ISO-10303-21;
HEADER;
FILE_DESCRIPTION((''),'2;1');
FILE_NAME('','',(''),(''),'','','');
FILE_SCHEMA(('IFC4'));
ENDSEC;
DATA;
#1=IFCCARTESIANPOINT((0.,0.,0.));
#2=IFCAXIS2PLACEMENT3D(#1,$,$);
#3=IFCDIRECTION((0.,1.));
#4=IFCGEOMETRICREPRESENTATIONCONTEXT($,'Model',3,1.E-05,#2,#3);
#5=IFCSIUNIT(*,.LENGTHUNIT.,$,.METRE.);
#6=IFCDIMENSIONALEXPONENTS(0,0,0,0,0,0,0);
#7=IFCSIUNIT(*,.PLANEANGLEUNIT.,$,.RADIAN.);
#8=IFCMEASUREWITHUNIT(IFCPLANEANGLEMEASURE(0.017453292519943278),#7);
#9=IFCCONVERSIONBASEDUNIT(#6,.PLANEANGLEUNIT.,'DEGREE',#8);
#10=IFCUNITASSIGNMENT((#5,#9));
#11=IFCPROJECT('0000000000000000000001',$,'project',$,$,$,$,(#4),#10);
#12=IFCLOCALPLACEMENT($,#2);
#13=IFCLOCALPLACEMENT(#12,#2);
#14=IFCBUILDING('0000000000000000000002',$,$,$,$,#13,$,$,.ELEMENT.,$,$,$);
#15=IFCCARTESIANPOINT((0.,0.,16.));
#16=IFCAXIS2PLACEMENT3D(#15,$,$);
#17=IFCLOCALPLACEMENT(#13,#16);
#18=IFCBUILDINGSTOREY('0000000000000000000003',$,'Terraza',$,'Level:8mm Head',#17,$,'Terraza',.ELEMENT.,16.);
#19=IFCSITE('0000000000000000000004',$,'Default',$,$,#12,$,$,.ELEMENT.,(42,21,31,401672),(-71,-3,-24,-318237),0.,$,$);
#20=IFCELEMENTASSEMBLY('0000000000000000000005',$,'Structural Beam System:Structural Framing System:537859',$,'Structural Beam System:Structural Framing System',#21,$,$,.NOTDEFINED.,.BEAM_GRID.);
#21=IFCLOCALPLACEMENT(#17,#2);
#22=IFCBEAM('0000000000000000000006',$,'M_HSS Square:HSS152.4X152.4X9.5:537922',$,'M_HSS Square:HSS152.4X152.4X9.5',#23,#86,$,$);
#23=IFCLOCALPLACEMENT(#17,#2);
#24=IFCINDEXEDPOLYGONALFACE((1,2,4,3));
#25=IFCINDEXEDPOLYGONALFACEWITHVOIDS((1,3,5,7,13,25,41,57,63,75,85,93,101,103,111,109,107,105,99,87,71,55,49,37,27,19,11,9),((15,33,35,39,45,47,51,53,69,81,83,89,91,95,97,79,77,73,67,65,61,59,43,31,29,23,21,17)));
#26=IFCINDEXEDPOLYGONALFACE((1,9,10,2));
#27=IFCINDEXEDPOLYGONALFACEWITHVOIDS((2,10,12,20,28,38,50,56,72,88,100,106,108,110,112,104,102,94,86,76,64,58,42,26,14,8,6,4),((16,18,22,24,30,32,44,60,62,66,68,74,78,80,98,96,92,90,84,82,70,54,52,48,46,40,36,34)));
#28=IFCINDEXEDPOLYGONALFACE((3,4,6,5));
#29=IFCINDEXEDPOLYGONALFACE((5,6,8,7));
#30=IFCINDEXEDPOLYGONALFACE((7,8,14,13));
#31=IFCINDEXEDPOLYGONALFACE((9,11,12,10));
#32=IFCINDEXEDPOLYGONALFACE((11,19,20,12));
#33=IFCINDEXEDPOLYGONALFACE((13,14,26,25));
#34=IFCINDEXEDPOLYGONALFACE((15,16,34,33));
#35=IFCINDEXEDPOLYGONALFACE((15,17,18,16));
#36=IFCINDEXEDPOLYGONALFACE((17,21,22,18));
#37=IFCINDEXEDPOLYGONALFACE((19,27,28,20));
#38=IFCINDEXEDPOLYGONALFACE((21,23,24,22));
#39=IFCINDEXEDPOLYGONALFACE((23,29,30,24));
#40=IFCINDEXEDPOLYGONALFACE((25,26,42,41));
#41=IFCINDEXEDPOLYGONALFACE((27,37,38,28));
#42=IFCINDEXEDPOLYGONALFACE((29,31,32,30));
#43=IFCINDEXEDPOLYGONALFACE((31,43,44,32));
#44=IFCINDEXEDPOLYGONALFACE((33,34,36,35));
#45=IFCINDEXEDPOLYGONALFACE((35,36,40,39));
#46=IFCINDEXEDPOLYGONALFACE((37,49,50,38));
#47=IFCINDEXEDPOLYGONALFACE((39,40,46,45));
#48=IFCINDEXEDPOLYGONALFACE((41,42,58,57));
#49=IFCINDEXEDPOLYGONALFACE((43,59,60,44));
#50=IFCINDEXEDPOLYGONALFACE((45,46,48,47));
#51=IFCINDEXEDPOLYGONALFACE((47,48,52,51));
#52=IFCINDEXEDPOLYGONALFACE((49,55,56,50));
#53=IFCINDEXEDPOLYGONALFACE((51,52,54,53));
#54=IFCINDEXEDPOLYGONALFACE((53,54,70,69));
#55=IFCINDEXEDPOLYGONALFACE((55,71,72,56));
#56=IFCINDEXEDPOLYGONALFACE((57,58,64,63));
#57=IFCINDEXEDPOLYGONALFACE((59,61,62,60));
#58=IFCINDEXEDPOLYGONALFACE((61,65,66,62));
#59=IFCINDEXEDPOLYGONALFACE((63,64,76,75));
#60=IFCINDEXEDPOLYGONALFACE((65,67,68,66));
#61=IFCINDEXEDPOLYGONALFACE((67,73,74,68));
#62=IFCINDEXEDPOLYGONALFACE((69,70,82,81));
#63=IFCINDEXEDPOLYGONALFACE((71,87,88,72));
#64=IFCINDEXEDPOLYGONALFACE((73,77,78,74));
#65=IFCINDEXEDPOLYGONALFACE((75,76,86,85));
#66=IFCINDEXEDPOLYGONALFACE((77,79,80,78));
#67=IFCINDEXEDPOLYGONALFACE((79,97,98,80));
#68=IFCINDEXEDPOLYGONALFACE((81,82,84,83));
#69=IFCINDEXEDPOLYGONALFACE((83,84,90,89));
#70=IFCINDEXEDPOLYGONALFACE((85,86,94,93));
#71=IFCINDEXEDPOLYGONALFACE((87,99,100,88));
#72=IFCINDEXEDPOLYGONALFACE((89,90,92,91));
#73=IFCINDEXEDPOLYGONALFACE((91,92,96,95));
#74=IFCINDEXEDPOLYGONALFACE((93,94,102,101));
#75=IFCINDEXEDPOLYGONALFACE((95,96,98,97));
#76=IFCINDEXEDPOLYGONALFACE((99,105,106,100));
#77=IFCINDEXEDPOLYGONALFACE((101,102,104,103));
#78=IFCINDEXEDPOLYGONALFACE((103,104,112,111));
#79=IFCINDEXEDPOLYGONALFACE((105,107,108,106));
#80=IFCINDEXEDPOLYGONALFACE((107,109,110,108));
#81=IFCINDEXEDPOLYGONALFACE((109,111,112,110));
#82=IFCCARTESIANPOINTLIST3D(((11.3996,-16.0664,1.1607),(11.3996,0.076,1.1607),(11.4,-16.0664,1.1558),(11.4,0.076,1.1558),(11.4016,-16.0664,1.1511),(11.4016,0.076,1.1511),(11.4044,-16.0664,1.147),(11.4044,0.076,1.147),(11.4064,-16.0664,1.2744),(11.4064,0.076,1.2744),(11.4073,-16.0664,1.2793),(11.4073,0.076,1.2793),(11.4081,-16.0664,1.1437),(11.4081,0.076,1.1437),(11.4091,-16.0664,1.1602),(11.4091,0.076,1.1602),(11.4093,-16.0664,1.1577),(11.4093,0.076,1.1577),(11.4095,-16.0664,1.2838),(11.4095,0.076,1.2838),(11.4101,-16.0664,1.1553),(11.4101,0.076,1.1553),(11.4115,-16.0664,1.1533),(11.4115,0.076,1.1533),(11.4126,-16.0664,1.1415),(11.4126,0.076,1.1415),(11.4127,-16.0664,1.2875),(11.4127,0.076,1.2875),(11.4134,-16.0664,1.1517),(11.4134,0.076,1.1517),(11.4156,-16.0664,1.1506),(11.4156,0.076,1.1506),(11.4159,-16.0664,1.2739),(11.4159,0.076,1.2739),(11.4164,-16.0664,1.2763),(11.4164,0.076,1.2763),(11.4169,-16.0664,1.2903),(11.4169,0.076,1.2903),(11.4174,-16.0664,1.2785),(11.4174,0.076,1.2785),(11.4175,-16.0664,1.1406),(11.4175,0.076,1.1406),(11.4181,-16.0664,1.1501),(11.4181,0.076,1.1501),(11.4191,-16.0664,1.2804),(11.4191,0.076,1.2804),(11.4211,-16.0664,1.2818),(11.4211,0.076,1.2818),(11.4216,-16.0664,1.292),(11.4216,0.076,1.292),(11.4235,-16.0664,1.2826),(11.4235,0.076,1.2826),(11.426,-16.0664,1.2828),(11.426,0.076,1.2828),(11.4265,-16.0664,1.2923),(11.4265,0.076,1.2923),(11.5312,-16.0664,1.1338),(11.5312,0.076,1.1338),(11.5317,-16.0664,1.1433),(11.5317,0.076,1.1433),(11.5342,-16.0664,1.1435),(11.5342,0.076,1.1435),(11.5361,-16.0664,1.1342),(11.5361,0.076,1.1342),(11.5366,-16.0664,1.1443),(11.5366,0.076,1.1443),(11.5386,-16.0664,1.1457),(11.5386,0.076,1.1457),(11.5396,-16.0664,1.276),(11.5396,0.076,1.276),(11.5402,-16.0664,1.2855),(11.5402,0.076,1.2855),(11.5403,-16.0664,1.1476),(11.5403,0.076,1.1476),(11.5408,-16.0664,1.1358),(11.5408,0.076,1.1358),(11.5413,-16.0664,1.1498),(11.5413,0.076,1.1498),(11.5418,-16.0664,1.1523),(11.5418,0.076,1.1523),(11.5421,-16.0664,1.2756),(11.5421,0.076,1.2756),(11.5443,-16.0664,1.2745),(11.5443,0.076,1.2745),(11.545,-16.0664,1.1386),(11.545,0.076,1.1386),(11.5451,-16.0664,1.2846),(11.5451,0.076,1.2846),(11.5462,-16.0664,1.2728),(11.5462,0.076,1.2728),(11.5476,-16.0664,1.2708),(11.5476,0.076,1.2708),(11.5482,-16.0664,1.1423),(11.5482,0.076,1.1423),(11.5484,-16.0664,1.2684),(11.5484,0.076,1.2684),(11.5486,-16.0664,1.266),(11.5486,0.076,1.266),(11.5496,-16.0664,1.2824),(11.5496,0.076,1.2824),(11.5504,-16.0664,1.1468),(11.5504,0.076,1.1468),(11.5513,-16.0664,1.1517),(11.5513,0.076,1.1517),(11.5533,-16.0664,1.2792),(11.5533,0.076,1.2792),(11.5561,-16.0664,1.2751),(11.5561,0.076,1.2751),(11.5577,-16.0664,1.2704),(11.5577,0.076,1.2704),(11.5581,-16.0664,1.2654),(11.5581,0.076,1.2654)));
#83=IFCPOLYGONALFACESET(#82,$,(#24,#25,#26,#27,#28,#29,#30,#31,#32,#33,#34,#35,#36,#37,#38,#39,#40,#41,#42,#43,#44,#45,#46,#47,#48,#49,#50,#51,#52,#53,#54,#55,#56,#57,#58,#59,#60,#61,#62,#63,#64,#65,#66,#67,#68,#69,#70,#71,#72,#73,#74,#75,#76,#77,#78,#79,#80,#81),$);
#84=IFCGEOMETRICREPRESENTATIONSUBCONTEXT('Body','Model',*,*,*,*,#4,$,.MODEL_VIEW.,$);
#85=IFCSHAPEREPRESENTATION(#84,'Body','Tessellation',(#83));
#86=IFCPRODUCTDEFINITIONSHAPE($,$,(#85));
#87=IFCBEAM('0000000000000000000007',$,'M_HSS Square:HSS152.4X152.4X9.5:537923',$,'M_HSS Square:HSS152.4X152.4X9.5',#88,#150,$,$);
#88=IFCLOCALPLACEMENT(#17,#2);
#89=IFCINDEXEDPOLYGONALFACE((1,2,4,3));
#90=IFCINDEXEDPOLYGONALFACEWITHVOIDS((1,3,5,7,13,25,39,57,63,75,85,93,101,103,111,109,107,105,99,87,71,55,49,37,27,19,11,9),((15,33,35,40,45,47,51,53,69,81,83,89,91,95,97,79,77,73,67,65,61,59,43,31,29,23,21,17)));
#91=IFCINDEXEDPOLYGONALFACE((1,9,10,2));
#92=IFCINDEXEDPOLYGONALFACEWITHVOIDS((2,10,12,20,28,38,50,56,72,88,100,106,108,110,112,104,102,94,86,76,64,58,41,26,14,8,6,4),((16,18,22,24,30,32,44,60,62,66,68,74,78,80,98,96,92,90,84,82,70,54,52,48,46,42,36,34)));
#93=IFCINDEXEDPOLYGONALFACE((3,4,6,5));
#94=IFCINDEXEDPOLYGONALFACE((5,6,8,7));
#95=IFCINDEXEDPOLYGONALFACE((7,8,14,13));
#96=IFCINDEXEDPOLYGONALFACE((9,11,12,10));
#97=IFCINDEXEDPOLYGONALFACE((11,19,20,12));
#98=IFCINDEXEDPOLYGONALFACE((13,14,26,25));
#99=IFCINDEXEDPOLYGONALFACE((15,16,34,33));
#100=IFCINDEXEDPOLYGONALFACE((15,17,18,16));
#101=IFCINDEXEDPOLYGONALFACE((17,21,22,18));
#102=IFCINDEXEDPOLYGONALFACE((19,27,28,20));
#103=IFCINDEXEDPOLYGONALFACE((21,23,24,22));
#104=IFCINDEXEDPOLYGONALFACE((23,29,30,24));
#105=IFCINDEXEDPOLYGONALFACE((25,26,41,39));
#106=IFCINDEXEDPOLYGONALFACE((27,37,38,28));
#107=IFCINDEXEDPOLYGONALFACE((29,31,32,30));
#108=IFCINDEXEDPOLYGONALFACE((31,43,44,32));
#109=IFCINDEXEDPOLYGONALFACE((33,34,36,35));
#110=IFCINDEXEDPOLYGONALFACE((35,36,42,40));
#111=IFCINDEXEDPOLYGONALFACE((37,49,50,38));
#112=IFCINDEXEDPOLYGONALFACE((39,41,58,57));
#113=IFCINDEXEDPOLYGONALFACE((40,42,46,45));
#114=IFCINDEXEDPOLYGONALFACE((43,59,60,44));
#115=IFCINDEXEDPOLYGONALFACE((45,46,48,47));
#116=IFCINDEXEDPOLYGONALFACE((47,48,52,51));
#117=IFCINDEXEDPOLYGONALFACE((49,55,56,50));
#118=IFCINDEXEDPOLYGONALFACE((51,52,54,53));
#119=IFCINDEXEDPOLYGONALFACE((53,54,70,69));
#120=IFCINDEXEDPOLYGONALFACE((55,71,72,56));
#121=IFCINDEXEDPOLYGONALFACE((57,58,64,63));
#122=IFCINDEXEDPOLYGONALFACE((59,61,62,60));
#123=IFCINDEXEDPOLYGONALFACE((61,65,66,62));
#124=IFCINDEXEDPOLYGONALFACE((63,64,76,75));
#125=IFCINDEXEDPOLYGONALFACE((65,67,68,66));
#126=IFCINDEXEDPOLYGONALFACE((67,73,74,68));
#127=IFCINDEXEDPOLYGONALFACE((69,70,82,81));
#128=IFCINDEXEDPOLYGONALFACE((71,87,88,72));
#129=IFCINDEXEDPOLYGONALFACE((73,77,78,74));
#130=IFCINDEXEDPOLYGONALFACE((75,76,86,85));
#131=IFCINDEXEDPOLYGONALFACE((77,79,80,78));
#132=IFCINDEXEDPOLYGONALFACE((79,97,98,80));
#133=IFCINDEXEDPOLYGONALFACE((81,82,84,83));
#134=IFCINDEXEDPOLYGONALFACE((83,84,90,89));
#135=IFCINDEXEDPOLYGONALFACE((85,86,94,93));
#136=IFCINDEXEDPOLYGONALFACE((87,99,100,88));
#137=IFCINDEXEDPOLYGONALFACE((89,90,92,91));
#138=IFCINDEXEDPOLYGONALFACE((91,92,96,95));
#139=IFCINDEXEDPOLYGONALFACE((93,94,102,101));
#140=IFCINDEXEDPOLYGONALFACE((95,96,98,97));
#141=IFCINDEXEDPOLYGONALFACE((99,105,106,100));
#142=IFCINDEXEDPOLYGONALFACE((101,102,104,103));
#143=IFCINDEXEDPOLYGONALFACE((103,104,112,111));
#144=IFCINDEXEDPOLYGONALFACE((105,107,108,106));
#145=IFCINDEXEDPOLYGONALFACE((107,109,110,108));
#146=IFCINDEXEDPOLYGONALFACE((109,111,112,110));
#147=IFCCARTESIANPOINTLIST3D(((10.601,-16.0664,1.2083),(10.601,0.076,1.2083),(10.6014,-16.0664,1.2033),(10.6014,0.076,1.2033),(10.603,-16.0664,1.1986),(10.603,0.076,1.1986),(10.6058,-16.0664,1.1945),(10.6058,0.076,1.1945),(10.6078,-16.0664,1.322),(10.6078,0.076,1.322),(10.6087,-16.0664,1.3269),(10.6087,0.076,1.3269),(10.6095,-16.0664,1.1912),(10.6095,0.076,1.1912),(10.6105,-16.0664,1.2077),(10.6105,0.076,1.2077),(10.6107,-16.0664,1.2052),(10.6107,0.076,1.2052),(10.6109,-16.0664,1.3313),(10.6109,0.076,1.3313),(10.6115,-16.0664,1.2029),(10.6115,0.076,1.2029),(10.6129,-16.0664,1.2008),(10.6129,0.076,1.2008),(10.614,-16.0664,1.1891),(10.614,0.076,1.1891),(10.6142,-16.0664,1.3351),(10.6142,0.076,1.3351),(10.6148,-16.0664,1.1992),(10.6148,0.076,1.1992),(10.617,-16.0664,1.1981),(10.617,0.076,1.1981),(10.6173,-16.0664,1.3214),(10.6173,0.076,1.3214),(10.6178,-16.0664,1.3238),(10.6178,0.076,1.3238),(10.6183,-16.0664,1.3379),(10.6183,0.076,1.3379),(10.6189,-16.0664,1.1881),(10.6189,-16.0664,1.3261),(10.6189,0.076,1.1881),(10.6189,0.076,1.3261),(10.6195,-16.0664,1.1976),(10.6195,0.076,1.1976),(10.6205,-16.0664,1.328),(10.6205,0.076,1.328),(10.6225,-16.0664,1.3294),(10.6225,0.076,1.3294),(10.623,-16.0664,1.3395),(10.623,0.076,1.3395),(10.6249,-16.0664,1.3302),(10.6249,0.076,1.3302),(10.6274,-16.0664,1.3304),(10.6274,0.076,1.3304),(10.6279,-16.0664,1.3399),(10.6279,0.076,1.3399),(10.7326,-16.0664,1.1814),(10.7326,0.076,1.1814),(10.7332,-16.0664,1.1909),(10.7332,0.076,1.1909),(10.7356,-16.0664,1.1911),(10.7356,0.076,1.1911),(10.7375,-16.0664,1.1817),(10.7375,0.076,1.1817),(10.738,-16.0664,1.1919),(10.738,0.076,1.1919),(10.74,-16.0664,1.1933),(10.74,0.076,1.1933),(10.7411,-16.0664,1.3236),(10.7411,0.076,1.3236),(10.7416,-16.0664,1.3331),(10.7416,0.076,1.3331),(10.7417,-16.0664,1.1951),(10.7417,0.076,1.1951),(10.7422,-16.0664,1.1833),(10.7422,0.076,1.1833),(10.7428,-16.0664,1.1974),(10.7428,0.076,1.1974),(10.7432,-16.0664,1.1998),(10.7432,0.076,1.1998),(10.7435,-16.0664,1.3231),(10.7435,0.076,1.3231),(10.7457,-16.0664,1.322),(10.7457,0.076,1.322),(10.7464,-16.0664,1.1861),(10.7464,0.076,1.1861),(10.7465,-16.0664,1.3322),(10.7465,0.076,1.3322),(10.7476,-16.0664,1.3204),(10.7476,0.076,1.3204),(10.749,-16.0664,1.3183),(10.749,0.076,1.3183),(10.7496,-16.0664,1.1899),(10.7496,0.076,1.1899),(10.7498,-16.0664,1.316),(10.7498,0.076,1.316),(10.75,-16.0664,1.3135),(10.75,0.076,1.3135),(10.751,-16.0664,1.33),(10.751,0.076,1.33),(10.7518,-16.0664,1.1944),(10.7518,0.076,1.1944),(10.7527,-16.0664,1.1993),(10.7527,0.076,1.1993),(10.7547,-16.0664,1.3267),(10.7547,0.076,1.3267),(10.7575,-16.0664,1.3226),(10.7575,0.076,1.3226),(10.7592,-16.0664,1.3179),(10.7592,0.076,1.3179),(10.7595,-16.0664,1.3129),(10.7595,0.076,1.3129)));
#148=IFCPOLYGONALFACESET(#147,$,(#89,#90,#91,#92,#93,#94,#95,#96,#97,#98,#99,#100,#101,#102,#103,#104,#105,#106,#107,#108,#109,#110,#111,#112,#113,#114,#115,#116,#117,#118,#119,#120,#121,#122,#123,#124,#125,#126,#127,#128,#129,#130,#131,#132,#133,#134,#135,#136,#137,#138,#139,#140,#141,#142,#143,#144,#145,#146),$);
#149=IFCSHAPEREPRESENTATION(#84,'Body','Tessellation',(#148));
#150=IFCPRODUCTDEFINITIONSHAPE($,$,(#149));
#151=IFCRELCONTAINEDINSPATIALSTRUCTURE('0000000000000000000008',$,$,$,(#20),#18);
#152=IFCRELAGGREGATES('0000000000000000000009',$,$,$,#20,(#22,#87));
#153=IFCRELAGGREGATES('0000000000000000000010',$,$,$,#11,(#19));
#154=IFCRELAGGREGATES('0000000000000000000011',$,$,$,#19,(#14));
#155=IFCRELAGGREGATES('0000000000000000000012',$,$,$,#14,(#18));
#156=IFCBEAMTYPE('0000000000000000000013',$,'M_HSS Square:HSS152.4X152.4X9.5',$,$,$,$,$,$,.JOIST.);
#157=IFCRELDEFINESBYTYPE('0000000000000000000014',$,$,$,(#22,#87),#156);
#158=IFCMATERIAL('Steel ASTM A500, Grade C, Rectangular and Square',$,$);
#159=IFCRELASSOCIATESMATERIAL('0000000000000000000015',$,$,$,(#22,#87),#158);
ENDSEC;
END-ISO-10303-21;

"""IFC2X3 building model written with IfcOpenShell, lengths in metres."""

from ifc_helpers import new_model, entity, si_unit, converted_unit, direction, frame, frame_2d, origin, place, context, subcontext, project, spatial, polyline, circle_curve, parameter, trimmed, segment, composite_curve, outline, extrude, material, type_object, element, aggregate, save


model = new_model("IFC2X3")

# Units and contexts
model_context = context("Model", 3, precision=1e-05, world=origin(), true_north=direction((0.0, 1.0)))
body_context = subcontext(model_context, "Body", "Model", "MODEL_VIEW")
ifc_project = project(units=[si_unit("LENGTHUNIT", "METRE"), converted_unit("PLANEANGLEUNIT", "DEGREE", entity("IfcPlaneAngleMeasure", 0.017453292519943278), si_unit("PLANEANGLEUNIT", "RADIAN"), dimensions=[0, 0, 0, 0, 0, 0, 0])], contexts=[model_context])

# Site, building, storey
site_placement = place(None, origin())
site = spatial("IfcSite", under=ifc_project, at=site_placement, Name="Default", CompositionType="ELEMENT", RefLatitude=(42, 21, 31, 401672), RefLongitude=(-71, -3, -24, -318237), RefElevation=0.0)
building_placement = place(site_placement, origin())
building = spatial("IfcBuilding", under=site, at=building_placement, CompositionType="ELEMENT")
storey_placement = place(building_placement, frame((0.0, 0.0, 16.0)))
storey = spatial("IfcBuildingStorey", under=building, at=storey_placement, Name="Terraza", ObjectType="Level:8mm Head", LongName="Terraza", CompositionType="ELEMENT", Elevation=16.0)

# Element assembly, beams
assembly_1_placement = place(storey_placement, origin())
assembly_1 = element("IfcElementAssembly", 1, at=assembly_1_placement, inside=storey, Name="Structural Beam System:Structural Framing System:537859", ObjectType="Structural Beam System:Structural Framing System", AssemblyPlace="NOTDEFINED", PredefinedType="BEAM_GRID")
ifc_material_1 = material(Name="Steel ASTM A500, Grade C, Rectangular and Square")
beam_type = type_object("IfcBeamType", Name="M_HSS Square:HSS152.4X152.4X9.5", PredefinedType="JOIST")
beam_1_placement = place(assembly_1_placement, frame((11.4743, 0.076, 1.1372), z_axis=(0.0, 0.0, 1.0), x_axis=(0.0, -1.0, 0.0)))
beam_1 = element("IfcBeam", 2, at=beam_1_placement, type_object=beam_type, material=ifc_material_1, Name="M_HSS Square:HSS152.4X152.4X9.5:537922", ObjectType="M_HSS Square:HSS152.4X152.4X9.5", context=body_context, shape_type="SweptSolid", body=[
    extrude(outline(composite_curve([segment(polyline([(-0.0569, -0.076), (0.0569, -0.076)]), True, "CONTINUOUS"), segment(trimmed(circle_curve(frame_2d((0.0569, -0.0569), x_axis=(0.0, 1.0)), 0.0191), [parameter(180.0)], [parameter(270.0)], True, "PARAMETER"), True, "CONTINUOUS"), segment(polyline([(0.076, -0.0569), (0.076, 0.0569)]), True, "CONTINUOUS"), segment(trimmed(circle_curve(frame_2d((0.0569, 0.0569), x_axis=(0.0, 1.0)), 0.0191), [parameter(270.0)], [parameter(0.0)], True, "PARAMETER"), True, "CONTINUOUS"), segment(polyline([(0.0569, 0.076), (-0.0569, 0.076)]), True, "CONTINUOUS"), segment(trimmed(circle_curve(frame_2d((-0.0569, 0.0569), x_axis=(0.0, 1.0)), 0.0191), [parameter(0.0)], [parameter(90.0)], True, "PARAMETER"), True, "CONTINUOUS"), segment(polyline([(-0.076, 0.0569), (-0.076, -0.0569)]), True, "CONTINUOUS"), segment(trimmed(circle_curve(frame_2d((-0.0569, -0.0569), x_axis=(0.0, 1.0)), 0.0191), [parameter(90.0)], [parameter(180.0)], True, "PARAMETER"), True, "CONTINUOUS")], self_intersect=False), holes=[composite_curve([segment(trimmed(circle_curve(frame_2d((-0.0569, 0.0569), x_axis=(0.0, 1.0)), 0.0095), [parameter(360.0)], [parameter(90.0)], True, "PARAMETER"), False, "CONTINUOUS"), segment(polyline([(-0.0569, 0.0665), (0.0569, 0.0665)]), True, "CONTINUOUS"), segment(trimmed(circle_curve(frame_2d((0.0569, 0.0569), x_axis=(0.0, 1.0)), 0.0095), [parameter(270.0)], [parameter(360.0)], True, "PARAMETER"), False, "CONTINUOUS"), segment(polyline([(0.0665, 0.0569), (0.0665, -0.0569)]), True, "CONTINUOUS"), segment(trimmed(circle_curve(frame_2d((0.0569, -0.0569), x_axis=(0.0, 1.0)), 0.0095), [parameter(180.0)], [parameter(270.0)], True, "PARAMETER"), False, "CONTINUOUS"), segment(polyline([(0.0569, -0.0665), (-0.0569, -0.0665)]), True, "CONTINUOUS"), segment(trimmed(circle_curve(frame_2d((-0.0569, -0.0569), x_axis=(0.0, 1.0)), 0.0095), [parameter(90.0)], [parameter(180.0)], True, "PARAMETER"), False, "CONTINUOUS"), segment(polyline([(-0.0665, -0.0569), (-0.0665, 0.0569)]), True, "CONTINUOUS")], self_intersect=False)]), frame((0.0, 0.0045, 0.0759), z_axis=(1.0, 0.0, 0.0), x_axis=(0.0, -0.059434, -0.998232)), (0.0, 0.0, 1.0), 16.1424),
])
beam_2_placement = place(assembly_1_placement, frame((10.6757, 0.076, 1.1847), z_axis=(0.0, 0.0, 1.0), x_axis=(0.0, -1.0, 0.0)))
beam_2 = element("IfcBeam", 3, at=beam_2_placement, type_object=beam_type, material=ifc_material_1, Name="M_HSS Square:HSS152.4X152.4X9.5:537923", ObjectType="M_HSS Square:HSS152.4X152.4X9.5", context=body_context, shape_type="SweptSolid", body=[
    extrude(outline(composite_curve([segment(polyline([(-0.0569, -0.076), (0.0569, -0.076)]), True, "CONTINUOUS"), segment(trimmed(circle_curve(frame_2d((0.0569, -0.0569), x_axis=(0.0, 1.0)), 0.0191), [parameter(180.0)], [parameter(270.0)], True, "PARAMETER"), True, "CONTINUOUS"), segment(polyline([(0.076, -0.0569), (0.076, 0.0569)]), True, "CONTINUOUS"), segment(trimmed(circle_curve(frame_2d((0.0569, 0.0569), x_axis=(0.0, 1.0)), 0.0191), [parameter(270.0)], [parameter(0.0)], True, "PARAMETER"), True, "CONTINUOUS"), segment(polyline([(0.0569, 0.076), (-0.0569, 0.076)]), True, "CONTINUOUS"), segment(trimmed(circle_curve(frame_2d((-0.0569, 0.0569), x_axis=(0.0, 1.0)), 0.0191), [parameter(0.0)], [parameter(90.0)], True, "PARAMETER"), True, "CONTINUOUS"), segment(polyline([(-0.076, 0.0569), (-0.076, -0.0569)]), True, "CONTINUOUS"), segment(trimmed(circle_curve(frame_2d((-0.0569, -0.0569), x_axis=(0.0, 1.0)), 0.0191), [parameter(90.0)], [parameter(180.0)], True, "PARAMETER"), True, "CONTINUOUS")], self_intersect=False), holes=[composite_curve([segment(trimmed(circle_curve(frame_2d((-0.0569, 0.0569), x_axis=(0.0, 1.0)), 0.0095), [parameter(360.0)], [parameter(90.0)], True, "PARAMETER"), False, "CONTINUOUS"), segment(polyline([(-0.0569, 0.0665), (0.0569, 0.0665)]), True, "CONTINUOUS"), segment(trimmed(circle_curve(frame_2d((0.0569, 0.0569), x_axis=(0.0, 1.0)), 0.0095), [parameter(270.0)], [parameter(360.0)], True, "PARAMETER"), False, "CONTINUOUS"), segment(polyline([(0.0665, 0.0569), (0.0665, -0.0569)]), True, "CONTINUOUS"), segment(trimmed(circle_curve(frame_2d((0.0569, -0.0569), x_axis=(0.0, 1.0)), 0.0095), [parameter(180.0)], [parameter(270.0)], True, "PARAMETER"), False, "CONTINUOUS"), segment(polyline([(0.0569, -0.0665), (-0.0569, -0.0665)]), True, "CONTINUOUS"), segment(trimmed(circle_curve(frame_2d((-0.0569, -0.0569), x_axis=(0.0, 1.0)), 0.0095), [parameter(90.0)], [parameter(180.0)], True, "PARAMETER"), False, "CONTINUOUS"), segment(polyline([(-0.0665, -0.0569), (-0.0665, 0.0569)]), True, "CONTINUOUS")], self_intersect=False)]), frame((0.0, 0.0045, 0.0759), z_axis=(1.0, 0.0, 0.0), x_axis=(0.0, -0.059434, -0.998232)), (0.0, 0.0, 1.0), 16.1424),
])
aggregate(assembly_1, [beam_1, beam_2])

save(model, "model.ifc")
